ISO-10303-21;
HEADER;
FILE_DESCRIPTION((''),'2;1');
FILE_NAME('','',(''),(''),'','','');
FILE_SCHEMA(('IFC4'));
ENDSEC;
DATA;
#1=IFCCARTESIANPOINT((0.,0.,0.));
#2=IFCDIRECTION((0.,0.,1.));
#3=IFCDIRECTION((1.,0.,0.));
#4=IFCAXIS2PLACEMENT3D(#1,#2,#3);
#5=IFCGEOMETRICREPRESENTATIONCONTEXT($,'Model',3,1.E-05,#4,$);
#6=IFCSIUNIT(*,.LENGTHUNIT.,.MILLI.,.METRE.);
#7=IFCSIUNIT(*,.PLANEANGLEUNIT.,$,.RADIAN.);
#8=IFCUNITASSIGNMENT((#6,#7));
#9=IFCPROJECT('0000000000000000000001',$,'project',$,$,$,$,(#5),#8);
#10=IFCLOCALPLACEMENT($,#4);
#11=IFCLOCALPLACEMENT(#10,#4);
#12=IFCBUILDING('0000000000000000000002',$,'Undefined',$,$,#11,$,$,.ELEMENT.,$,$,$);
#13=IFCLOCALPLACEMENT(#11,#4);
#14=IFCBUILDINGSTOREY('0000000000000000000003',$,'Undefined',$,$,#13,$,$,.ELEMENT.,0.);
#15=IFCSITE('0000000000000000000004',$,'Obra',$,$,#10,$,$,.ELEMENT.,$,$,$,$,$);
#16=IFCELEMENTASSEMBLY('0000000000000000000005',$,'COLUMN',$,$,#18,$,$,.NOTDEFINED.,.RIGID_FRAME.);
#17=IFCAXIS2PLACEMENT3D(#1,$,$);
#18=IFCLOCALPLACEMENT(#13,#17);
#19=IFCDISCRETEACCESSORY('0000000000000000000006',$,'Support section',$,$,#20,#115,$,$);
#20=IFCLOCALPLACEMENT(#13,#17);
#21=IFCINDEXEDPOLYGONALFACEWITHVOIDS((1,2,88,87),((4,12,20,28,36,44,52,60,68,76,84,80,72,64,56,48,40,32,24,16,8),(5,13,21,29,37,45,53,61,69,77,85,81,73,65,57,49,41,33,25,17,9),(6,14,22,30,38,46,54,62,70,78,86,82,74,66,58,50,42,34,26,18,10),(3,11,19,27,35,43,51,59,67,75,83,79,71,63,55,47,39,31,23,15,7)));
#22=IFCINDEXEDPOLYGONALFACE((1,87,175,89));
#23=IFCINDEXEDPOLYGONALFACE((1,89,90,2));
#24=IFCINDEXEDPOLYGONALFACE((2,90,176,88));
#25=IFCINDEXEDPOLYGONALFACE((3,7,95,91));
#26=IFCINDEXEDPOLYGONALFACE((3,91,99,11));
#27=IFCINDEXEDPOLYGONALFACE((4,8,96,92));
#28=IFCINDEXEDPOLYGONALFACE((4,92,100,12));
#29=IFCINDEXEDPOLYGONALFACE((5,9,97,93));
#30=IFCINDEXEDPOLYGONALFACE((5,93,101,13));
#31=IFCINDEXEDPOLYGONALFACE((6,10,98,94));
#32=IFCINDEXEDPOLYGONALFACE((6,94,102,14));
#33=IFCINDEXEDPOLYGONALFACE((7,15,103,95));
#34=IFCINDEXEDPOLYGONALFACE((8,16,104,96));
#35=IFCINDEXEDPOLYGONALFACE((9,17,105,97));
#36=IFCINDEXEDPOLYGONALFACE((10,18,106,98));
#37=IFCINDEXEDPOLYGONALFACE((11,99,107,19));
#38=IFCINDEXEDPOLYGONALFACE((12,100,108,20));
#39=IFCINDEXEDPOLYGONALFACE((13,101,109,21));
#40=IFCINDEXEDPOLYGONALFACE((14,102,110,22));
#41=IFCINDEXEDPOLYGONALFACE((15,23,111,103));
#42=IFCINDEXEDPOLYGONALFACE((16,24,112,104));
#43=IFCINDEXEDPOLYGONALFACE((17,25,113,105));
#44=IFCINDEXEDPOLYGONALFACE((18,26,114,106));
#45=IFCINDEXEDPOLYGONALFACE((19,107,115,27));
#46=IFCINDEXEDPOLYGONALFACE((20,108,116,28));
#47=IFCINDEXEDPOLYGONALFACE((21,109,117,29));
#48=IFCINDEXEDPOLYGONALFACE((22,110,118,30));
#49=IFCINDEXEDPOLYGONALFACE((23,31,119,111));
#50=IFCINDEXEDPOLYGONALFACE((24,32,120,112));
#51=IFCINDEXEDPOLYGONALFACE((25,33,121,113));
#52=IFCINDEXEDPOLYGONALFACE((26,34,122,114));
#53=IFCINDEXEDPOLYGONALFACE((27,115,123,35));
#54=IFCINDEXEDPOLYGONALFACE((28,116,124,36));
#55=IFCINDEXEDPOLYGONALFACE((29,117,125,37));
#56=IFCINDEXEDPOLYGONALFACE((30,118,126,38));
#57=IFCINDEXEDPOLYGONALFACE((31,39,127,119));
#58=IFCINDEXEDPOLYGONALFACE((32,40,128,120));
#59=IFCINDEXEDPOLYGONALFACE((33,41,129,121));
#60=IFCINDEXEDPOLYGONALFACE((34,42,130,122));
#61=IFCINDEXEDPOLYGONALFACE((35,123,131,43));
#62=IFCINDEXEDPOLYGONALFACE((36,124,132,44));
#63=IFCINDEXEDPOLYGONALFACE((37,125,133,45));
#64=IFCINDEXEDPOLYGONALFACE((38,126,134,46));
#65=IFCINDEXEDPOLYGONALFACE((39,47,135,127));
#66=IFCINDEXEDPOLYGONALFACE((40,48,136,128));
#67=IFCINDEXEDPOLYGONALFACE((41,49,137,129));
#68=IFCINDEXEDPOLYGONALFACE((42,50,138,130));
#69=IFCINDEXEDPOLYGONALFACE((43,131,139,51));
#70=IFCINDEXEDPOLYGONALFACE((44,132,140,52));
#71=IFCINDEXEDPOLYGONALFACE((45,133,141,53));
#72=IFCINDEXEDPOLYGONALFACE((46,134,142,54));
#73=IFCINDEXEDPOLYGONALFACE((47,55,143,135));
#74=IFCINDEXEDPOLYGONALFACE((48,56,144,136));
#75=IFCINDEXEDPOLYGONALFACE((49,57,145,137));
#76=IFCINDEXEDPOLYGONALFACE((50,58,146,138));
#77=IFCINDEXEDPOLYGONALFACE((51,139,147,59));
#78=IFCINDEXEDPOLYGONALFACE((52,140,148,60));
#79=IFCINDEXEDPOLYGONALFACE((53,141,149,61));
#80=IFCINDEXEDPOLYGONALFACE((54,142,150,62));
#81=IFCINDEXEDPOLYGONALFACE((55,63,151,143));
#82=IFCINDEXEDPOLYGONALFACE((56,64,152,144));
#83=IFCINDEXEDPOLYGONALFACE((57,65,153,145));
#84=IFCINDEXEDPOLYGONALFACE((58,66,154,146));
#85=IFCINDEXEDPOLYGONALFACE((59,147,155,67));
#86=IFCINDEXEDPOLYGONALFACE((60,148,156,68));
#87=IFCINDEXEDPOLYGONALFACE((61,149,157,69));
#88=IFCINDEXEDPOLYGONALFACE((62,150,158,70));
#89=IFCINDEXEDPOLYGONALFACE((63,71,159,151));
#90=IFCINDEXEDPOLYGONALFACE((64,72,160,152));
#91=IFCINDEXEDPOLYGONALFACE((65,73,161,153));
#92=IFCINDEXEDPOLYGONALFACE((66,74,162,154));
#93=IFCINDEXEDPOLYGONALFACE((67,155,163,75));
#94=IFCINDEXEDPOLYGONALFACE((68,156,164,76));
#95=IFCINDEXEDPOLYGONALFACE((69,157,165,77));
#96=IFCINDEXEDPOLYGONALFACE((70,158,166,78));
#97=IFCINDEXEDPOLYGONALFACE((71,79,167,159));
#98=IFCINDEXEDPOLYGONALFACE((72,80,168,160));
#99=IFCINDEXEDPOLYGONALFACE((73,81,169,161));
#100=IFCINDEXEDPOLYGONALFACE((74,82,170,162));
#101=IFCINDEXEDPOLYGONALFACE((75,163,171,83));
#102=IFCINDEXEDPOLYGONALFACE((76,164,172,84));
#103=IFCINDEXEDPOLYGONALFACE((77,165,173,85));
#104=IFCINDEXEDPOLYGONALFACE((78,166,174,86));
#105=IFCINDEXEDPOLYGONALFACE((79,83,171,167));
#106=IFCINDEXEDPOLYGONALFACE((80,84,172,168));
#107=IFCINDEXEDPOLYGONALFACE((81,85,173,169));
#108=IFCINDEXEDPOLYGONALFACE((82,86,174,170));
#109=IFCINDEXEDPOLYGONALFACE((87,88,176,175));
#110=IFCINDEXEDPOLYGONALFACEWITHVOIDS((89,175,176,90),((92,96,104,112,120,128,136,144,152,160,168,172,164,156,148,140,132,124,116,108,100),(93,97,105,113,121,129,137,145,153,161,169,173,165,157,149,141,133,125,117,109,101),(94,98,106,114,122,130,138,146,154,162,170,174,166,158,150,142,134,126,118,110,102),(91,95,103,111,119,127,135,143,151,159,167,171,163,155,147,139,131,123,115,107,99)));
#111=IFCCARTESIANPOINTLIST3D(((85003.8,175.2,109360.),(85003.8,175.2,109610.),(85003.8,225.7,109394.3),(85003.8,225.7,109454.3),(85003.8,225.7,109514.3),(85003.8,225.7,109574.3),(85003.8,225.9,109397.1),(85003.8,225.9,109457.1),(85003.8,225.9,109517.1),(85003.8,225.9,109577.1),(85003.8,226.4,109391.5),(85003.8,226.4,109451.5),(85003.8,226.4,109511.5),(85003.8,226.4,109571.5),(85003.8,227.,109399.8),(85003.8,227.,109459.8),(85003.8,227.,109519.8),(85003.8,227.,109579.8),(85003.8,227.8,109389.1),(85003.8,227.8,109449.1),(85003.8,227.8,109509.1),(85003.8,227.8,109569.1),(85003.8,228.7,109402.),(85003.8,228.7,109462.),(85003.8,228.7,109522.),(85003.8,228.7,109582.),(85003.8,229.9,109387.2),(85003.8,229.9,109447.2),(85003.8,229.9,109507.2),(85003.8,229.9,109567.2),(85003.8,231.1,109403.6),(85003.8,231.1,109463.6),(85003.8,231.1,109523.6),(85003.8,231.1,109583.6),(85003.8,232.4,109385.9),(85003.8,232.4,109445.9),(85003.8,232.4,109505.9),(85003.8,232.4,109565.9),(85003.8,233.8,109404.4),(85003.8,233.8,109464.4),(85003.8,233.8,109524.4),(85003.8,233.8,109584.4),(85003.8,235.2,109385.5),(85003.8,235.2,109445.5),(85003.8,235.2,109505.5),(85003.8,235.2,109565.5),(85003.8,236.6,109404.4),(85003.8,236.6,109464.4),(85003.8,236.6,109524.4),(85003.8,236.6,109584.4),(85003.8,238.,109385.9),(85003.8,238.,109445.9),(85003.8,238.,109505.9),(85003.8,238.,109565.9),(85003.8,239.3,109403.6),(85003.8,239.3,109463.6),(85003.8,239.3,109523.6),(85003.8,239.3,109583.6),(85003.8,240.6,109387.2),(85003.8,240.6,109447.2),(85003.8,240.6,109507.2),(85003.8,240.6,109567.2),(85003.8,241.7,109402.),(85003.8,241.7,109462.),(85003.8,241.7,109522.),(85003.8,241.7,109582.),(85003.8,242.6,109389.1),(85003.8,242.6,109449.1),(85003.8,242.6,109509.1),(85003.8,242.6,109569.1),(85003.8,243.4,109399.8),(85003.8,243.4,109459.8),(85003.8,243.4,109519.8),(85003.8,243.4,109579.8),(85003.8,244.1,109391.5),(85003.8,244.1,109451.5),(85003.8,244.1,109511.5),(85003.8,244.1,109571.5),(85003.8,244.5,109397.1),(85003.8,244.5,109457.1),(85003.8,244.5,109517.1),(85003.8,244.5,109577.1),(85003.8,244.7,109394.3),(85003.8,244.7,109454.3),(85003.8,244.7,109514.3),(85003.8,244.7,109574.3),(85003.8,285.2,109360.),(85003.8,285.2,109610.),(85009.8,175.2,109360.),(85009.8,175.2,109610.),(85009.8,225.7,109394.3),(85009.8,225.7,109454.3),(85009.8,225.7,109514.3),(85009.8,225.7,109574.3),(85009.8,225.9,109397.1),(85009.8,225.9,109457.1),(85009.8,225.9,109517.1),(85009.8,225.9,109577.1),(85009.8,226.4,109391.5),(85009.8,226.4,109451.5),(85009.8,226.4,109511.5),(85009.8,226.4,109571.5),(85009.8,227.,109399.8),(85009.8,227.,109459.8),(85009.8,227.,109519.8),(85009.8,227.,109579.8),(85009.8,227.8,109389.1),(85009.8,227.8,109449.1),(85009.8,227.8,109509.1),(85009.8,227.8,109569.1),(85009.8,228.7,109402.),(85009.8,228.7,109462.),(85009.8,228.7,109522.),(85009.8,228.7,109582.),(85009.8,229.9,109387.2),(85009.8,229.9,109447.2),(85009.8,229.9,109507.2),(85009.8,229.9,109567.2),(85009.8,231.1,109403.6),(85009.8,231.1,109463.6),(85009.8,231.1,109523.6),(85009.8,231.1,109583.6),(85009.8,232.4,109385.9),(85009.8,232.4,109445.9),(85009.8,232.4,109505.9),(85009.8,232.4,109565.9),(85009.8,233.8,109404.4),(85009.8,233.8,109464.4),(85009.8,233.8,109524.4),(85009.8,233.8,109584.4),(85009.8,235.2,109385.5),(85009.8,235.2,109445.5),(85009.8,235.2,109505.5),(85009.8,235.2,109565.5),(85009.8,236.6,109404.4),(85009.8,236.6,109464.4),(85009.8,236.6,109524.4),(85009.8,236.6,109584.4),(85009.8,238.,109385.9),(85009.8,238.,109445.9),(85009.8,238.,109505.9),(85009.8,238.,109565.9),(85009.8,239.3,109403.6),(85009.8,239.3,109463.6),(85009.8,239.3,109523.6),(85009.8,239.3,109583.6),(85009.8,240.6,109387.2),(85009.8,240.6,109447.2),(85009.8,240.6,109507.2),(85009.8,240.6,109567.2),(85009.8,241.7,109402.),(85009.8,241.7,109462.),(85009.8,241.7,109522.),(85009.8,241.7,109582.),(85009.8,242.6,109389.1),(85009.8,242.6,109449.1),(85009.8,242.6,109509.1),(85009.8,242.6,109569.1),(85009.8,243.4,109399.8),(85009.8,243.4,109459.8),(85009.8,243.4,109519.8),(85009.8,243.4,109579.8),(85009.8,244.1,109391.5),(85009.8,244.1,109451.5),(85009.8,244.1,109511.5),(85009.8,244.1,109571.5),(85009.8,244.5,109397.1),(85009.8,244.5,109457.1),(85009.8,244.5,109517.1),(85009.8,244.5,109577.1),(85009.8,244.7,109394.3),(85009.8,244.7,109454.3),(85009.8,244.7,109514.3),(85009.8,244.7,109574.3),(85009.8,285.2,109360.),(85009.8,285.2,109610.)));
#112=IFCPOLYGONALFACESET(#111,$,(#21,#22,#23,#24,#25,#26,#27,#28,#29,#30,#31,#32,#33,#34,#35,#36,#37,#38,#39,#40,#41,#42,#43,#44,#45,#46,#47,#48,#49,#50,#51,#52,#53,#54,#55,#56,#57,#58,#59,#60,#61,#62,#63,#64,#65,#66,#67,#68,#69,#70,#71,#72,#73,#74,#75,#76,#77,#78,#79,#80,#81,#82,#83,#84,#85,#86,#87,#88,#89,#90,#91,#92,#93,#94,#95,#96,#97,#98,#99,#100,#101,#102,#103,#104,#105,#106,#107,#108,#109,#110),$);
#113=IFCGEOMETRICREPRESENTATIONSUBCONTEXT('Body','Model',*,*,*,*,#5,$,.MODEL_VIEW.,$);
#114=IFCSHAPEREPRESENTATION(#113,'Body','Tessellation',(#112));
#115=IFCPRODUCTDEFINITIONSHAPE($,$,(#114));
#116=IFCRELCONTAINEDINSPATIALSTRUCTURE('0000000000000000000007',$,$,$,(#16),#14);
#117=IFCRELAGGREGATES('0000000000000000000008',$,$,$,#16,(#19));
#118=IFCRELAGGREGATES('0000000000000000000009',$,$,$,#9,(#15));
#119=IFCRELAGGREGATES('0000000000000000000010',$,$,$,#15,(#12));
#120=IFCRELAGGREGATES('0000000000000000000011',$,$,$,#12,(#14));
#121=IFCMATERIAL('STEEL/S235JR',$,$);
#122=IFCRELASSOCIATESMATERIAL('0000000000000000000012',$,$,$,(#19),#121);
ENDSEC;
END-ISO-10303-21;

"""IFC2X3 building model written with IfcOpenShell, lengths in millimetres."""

from ifc_helpers import new_model, si_unit, frame, origin_with_axes, origin_2d_with_axis, place, context, subcontext, project, spatial, rectangle, circle, extrude, source, transform, mapped, material, element, aggregate, save


model = new_model("IFC2X3")

# Units and contexts
model_context = context("Model", 3, precision=1e-05, world=origin_with_axes())
body_context = subcontext(model_context, "Body", "Model", "MODEL_VIEW")
ifc_project = project(units=[si_unit("LENGTHUNIT", "METRE", prefix="MILLI"), si_unit("PLANEANGLEUNIT", "RADIAN")], contexts=[model_context])

# Site, building, storey
site_placement = place(None, origin_with_axes())
site = spatial("IfcSite", under=ifc_project, at=site_placement, Name="Obra", CompositionType="ELEMENT")
building_placement = place(site_placement, origin_with_axes())
building = spatial("IfcBuilding", under=site, at=building_placement, Name="Undefined", CompositionType="ELEMENT")
storey_placement = place(building_placement, origin_with_axes())
storey = spatial("IfcBuildingStorey", under=building, at=storey_placement, Name="Undefined", CompositionType="ELEMENT", Elevation=0.0)

# Element assembly, discrete accessory, opening
assembly_1_placement = place(storey_placement, origin_with_axes())
assembly_1 = element("IfcElementAssembly", 1, at=assembly_1_placement, inside=storey, Name="COLUMN", AssemblyPlace="NOTDEFINED", PredefinedType="RIGID_FRAME")
ifc_material_1 = material(Name="STEEL/S235JR")
discrete_accessory_1_placement = place(assembly_1_placement, frame((85006.8, 230.2, 109360.0), z_axis=(0.0, 0.0, 1.0), x_axis=(0.0, -1.0, 0.0)))
discrete_accessory_1 = element("IfcDiscreteAccessory", 2, at=discrete_accessory_1_placement, material=ifc_material_1, Name="Support section", context=body_context, shape_type="SweptSolid", body=[
    extrude(rectangle(XDim=6.0, YDim=110.0, at=origin_2d_with_axis()), frame((0.0, 0.0, 250.0), z_axis=(0.0, 0.0, -1.0), x_axis=(0.0, 1.0, 0.0)), (0.0, 0.0, 1.0), 250.0),
])
shared_shape_1 = source(origin_with_axes(), body_context, "Body", "SweptSolid", [
    extrude(circle(Radius=9.5, at=origin_2d_with_axis()), frame((0.0, -9.8, 0.0), z_axis=(0.0, 1.0, 0.0), x_axis=(1.0, 0.0, 0.0)), (0.0, 0.0, 1.0), 6.2),
])
opening_1_placement = place(assembly_1_placement, frame((85000.0, 185.2, 109650.0), z_axis=(0.0, 1.0, 0.0), x_axis=(0.0, 0.0, -1.0)))
element("IfcOpeningElement", 3, at=opening_1_placement, cuts=discrete_accessory_1, ObjectType="Opening", context=body_context, shape_type="MappedRepresentation", body=[
    mapped(shared_shape_1, transform((75.0, 0.0, 50.0))),
    mapped(shared_shape_1, transform((135.0, 0.0, 50.0))),
    mapped(shared_shape_1, transform((195.0, 0.0, 50.0))),
    mapped(shared_shape_1, transform((255.0, 0.0, 50.0))),
])
aggregate(assembly_1, [discrete_accessory_1])

save(model, "model.ifc")
